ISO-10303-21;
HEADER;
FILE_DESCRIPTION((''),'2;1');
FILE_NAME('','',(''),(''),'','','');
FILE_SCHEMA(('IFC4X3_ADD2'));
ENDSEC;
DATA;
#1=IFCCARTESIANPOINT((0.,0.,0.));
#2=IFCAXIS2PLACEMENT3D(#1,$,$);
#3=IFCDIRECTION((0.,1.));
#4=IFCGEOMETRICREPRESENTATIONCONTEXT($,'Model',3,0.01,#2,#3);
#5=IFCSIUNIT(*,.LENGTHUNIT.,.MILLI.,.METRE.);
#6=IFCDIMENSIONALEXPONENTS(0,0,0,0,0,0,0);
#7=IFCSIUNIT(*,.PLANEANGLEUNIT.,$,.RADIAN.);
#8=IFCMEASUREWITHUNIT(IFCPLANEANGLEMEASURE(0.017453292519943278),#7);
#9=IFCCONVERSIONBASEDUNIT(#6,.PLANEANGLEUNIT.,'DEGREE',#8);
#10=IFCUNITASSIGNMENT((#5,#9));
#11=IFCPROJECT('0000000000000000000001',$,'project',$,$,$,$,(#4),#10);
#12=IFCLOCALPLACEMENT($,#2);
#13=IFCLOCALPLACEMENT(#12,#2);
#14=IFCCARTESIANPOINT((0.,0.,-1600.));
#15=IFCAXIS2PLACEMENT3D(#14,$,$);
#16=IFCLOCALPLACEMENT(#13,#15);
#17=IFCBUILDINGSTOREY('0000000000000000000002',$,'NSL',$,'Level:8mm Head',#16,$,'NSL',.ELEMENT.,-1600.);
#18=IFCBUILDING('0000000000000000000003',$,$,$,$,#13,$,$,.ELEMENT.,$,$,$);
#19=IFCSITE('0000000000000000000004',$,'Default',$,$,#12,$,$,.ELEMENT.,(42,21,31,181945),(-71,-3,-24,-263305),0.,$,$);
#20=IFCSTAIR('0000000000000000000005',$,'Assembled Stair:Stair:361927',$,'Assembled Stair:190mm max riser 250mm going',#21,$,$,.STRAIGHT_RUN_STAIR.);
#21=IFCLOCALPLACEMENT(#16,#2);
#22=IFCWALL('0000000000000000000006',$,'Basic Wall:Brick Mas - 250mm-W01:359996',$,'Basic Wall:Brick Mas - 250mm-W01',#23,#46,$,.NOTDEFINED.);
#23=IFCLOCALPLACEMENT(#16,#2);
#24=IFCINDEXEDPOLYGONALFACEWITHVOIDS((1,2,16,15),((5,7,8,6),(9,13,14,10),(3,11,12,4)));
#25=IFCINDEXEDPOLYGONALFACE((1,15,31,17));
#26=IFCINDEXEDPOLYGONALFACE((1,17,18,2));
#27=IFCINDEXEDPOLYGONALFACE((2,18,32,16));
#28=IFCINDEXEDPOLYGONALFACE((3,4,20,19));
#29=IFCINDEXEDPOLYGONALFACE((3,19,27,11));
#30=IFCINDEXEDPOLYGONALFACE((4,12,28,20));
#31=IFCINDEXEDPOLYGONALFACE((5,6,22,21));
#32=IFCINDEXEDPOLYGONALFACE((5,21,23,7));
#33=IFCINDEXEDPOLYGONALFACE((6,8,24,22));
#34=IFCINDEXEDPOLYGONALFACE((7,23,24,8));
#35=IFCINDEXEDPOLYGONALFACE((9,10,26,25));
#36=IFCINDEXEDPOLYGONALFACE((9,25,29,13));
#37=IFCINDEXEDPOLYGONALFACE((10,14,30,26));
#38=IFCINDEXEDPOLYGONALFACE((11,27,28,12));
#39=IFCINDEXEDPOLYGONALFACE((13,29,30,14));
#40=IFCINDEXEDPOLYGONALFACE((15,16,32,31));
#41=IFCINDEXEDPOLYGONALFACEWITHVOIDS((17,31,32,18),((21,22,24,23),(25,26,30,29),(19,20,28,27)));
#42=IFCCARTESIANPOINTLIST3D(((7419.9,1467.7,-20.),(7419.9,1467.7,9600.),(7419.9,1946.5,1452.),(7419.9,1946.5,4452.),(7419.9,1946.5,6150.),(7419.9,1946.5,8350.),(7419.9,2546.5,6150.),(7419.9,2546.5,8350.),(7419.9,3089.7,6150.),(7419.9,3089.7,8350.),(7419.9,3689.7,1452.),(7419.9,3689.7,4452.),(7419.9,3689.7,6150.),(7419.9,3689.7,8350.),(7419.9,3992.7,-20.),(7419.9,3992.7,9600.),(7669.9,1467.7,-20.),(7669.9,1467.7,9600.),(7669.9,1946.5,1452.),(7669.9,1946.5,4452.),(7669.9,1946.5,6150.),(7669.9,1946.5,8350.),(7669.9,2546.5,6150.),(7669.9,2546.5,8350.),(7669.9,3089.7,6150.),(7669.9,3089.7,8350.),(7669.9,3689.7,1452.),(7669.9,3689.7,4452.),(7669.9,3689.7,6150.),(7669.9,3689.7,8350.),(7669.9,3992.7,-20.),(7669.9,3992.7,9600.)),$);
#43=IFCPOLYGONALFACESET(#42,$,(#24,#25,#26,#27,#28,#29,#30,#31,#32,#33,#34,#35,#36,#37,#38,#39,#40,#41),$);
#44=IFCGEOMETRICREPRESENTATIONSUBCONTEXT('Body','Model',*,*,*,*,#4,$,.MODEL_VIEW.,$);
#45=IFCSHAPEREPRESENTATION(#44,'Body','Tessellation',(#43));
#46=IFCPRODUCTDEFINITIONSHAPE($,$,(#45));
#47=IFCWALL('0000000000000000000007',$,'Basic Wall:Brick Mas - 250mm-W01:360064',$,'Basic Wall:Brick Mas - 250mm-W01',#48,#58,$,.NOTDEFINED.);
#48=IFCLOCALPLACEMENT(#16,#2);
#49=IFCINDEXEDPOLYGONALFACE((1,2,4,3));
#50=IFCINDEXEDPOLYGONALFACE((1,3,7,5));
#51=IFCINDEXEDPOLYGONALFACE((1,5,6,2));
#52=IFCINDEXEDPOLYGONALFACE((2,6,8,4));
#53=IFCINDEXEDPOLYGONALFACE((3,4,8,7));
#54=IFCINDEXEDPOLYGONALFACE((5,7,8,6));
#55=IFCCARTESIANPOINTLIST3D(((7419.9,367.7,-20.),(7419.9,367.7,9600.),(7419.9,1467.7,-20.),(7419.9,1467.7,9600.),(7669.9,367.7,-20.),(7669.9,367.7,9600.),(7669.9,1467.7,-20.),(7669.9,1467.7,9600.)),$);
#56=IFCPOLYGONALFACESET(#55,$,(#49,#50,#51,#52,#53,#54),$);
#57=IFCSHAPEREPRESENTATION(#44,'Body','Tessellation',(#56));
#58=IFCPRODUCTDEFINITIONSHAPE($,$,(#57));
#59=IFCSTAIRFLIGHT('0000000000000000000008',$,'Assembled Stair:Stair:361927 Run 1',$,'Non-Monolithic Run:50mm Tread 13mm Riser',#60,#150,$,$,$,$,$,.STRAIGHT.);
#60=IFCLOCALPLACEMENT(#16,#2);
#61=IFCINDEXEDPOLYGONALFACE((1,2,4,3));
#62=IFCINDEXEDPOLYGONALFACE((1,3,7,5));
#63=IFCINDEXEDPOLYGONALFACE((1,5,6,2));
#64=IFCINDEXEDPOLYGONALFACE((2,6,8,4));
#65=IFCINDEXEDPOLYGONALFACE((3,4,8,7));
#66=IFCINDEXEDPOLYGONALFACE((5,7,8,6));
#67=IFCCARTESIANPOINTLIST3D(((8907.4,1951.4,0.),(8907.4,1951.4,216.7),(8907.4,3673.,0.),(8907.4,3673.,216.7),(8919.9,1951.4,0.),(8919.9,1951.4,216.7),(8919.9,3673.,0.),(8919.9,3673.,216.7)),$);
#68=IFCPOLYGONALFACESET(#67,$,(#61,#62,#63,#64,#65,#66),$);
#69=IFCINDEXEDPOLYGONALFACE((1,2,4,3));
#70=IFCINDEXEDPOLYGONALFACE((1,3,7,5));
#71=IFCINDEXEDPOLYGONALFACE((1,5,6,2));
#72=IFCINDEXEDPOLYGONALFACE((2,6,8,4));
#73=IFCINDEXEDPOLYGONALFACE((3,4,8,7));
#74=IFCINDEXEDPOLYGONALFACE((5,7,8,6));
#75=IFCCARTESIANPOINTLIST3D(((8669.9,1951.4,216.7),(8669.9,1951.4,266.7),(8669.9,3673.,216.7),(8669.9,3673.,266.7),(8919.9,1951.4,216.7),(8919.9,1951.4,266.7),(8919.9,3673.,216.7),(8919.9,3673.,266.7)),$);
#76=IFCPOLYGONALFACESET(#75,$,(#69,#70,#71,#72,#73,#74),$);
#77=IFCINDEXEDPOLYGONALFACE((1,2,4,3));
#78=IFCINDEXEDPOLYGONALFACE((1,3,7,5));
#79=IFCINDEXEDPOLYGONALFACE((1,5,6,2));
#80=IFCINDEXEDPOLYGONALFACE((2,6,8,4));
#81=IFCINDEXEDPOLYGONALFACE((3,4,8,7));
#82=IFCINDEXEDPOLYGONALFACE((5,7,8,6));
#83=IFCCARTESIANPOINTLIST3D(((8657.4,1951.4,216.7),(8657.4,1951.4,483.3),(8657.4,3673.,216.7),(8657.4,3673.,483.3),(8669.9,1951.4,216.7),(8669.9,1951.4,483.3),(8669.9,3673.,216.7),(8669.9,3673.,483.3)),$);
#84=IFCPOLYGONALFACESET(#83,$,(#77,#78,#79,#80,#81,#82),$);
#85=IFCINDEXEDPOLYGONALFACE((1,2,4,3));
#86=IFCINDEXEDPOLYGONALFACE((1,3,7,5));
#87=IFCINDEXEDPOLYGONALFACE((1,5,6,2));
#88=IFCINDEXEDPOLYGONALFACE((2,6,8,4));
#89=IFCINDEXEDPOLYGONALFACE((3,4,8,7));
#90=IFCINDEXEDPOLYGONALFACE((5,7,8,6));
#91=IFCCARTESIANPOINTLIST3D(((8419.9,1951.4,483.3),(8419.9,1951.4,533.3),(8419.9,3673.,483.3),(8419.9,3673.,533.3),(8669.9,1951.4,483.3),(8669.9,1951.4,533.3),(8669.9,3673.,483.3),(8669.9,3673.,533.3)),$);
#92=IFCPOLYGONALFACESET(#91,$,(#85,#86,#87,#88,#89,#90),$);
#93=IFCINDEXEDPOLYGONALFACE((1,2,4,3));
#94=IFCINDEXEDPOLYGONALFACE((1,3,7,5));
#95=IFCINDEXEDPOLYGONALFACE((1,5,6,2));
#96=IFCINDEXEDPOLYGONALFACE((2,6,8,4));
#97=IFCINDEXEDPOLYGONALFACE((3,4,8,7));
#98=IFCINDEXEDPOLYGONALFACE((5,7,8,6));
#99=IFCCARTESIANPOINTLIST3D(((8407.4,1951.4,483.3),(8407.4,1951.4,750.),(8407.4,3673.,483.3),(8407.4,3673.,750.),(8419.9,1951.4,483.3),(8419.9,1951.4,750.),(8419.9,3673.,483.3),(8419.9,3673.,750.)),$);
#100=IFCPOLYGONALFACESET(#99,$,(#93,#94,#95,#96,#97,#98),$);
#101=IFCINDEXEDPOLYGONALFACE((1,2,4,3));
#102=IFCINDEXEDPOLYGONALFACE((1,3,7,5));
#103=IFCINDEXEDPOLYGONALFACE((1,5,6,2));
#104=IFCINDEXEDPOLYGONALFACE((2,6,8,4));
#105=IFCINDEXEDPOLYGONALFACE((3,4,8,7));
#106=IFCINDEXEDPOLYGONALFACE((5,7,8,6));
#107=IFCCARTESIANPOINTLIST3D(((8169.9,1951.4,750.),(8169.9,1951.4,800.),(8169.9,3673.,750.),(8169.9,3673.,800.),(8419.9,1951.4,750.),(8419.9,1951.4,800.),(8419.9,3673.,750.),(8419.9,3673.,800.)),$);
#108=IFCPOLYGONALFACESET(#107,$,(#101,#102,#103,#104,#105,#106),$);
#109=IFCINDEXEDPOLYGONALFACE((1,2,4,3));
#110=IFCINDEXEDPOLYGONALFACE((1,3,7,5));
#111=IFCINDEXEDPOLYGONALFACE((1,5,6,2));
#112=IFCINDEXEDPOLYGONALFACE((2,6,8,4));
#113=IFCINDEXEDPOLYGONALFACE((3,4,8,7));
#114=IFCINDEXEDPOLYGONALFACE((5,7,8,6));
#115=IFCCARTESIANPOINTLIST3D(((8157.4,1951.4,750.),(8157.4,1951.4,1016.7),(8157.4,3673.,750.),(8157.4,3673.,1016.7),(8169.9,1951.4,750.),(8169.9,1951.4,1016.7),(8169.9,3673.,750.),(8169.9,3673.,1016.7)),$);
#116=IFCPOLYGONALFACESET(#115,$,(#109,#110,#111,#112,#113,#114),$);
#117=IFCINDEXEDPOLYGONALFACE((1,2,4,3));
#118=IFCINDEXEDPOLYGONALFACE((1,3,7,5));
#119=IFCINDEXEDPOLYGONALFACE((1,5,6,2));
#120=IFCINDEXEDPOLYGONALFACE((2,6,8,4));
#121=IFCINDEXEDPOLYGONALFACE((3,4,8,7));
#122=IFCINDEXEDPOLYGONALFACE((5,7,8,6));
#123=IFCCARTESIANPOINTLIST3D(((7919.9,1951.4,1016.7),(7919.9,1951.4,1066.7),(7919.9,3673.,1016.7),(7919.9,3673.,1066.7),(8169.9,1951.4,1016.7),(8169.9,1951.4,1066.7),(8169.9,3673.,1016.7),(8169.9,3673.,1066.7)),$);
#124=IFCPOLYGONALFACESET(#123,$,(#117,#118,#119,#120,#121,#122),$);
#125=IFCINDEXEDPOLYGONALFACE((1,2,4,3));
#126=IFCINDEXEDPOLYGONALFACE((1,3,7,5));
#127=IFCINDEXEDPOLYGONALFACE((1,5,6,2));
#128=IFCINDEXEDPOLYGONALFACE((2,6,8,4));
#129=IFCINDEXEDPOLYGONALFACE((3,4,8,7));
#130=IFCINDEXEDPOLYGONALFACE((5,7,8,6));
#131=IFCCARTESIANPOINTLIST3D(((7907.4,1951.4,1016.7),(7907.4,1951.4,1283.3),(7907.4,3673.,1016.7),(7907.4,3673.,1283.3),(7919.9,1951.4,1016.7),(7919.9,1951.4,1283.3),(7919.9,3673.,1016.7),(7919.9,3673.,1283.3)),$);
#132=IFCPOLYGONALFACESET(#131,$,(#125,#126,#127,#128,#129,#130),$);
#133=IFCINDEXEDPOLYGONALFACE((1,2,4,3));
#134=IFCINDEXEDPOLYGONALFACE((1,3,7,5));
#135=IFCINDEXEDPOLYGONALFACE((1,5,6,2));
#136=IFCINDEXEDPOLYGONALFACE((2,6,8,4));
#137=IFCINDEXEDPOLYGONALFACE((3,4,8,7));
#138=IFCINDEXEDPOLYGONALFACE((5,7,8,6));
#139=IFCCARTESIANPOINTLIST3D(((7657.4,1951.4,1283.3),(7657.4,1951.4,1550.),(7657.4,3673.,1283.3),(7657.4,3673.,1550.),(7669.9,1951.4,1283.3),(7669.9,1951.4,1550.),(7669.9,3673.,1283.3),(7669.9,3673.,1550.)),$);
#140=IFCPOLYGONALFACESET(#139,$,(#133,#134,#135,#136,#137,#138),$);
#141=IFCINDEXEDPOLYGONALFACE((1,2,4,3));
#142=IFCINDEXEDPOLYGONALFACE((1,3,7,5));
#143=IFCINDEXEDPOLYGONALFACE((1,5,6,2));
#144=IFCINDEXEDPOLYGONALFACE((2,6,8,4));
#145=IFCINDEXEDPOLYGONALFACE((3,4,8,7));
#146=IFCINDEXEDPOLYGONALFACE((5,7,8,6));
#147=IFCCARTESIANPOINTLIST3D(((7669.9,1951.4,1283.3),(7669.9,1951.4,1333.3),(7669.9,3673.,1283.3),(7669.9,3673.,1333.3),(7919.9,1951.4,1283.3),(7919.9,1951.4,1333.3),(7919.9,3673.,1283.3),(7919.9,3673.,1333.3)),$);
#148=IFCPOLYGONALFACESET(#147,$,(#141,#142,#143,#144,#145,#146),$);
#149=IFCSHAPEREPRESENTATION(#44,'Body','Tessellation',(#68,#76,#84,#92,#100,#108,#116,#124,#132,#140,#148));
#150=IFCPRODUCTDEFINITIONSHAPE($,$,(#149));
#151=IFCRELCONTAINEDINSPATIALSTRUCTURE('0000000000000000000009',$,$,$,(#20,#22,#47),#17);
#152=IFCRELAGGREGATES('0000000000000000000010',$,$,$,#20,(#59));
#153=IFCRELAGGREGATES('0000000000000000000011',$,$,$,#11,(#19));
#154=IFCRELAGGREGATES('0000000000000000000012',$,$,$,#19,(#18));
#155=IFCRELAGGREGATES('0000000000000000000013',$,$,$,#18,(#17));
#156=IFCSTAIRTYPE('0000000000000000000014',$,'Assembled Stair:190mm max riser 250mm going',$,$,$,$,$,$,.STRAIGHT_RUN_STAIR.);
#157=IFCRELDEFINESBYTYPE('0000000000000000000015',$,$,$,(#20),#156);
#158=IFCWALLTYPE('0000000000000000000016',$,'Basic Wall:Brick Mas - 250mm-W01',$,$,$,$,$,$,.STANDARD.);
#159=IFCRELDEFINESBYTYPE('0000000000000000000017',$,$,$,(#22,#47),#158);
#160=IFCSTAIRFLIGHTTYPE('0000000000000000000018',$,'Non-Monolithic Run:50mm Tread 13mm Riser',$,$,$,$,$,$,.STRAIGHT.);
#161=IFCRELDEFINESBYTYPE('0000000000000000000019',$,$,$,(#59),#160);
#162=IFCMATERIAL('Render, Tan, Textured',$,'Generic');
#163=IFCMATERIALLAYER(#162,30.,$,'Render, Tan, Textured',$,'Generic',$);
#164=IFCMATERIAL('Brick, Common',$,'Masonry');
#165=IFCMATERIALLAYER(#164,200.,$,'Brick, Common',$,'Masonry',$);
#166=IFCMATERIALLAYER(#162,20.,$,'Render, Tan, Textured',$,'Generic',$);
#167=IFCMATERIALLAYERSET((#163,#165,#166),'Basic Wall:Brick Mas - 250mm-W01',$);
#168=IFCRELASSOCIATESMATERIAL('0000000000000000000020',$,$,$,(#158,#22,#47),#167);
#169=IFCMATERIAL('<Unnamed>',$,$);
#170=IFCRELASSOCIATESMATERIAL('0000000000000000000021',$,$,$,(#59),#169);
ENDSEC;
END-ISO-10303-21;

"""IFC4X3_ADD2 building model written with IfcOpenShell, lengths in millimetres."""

from ifc_helpers import new_model, entity, si_unit, converted_unit, direction, frame, frame_2d, origin, origin_2d_with_axis, place, context, subcontext, project, spatial, rectangle, extrude, material, layer, layer_set, type_object, element, aggregate, save


model = new_model("IFC4X3_ADD2")

# Units and contexts
model_context = context("Model", 3, precision=0.01, world=origin(), true_north=direction((0.0, 1.0)))
body_context = subcontext(model_context, "Body", "Model", "MODEL_VIEW")
ifc_project = project(units=[si_unit("LENGTHUNIT", "METRE", prefix="MILLI"), converted_unit("PLANEANGLEUNIT", "DEGREE", entity("IfcPlaneAngleMeasure", 0.017453292519943278), si_unit("PLANEANGLEUNIT", "RADIAN"), dimensions=[0, 0, 0, 0, 0, 0, 0])], contexts=[model_context])

# Site, building, storey
site_placement = place(None, origin())
site = spatial("IfcSite", under=ifc_project, at=site_placement, Name="Default", CompositionType="ELEMENT", RefLatitude=(42, 21, 31, 181945), RefLongitude=(-71, -3, -24, -263305), RefElevation=0.0)
building_placement = place(site_placement, origin())
building = spatial("IfcBuilding", under=site, at=building_placement, CompositionType="ELEMENT")
storey_placement = place(building_placement, frame((0.0, 0.0, -1600.0)))
storey = spatial("IfcBuildingStorey", under=building, at=storey_placement, Name="NSL", ObjectType="Level:8mm Head", LongName="NSL", CompositionType="ELEMENT", Elevation=-1600.0)

# Stair
stair_type = type_object("IfcStairType", Name="Assembled Stair:190mm max riser 250mm going", PredefinedType="STRAIGHT_RUN_STAIR")
stair_placement = place(storey_placement, origin())
stair = element("IfcStair", 1, at=stair_placement, inside=storey, type_object=stair_type, Name="Assembled Stair:Stair:361927", ObjectType="Assembled Stair:190mm max riser 250mm going", PredefinedType="STRAIGHT_RUN_STAIR")
ifc_material_1 = material(Name="<Unnamed>")

# Shared definitions
ifc_material_2 = material(Name="Render, Tan, Textured", Category="Generic")
ifc_layer_1 = layer(ifc_material_2, 30.0, Name="Render, Tan, Textured", Category="Generic")
ifc_material_3 = material(Name="Brick, Common", Category="Masonry")
ifc_layer_2 = layer(ifc_material_3, 200.0, Name="Brick, Common", Category="Masonry")
ifc_layer_3 = layer(ifc_material_2, 20.0, Name="Render, Tan, Textured", Category="Generic")
ifc_layer_set_1 = layer_set([ifc_layer_1, ifc_layer_2, ifc_layer_3], Name="Basic Wall:Brick Mas - 250mm-W01")
wall_type = type_object("IfcWallType", Name="Basic Wall:Brick Mas - 250mm-W01", PredefinedType="STANDARD", material=ifc_layer_set_1)

# Wall, openings
wall_1_placement = place(storey_placement, frame((7544.9, 3992.7, -20.0), z_axis=(0.0, 0.0, 1.0), x_axis=(0.0, -1.0, 0.0)))
wall_1 = element("IfcWall", 2, at=wall_1_placement, inside=storey, type_object=wall_type, material=ifc_layer_set_1, Name="Basic Wall:Brick Mas - 250mm-W01:359996", ObjectType="Basic Wall:Brick Mas - 250mm-W01", PredefinedType="NOTDEFINED", context=body_context, shape_type="SweptSolid", body=[
    extrude(rectangle(XDim=2525.0, YDim=250.0, at=frame_2d((1262.5, 0.0), x_axis=(-1.0, 0.0))), origin(), (0.0, 0.0, 1.0), 9620.0),
])
opening_1_placement = place(wall_1_placement, origin())
element("IfcOpeningElement", 3, at=opening_1_placement, cuts=wall_1, PredefinedType="OPENING", context=body_context, shape_type="SweptSolid", body=[
    extrude(rectangle(XDim=3000.0, YDim=1743.2, at=frame_2d((0.0, 0.0), x_axis=(1.0, 0.0))), frame((1174.6, 125.0, 2972.0), z_axis=(0.0, -1.0, 0.0), x_axis=(0.0, 0.0, -1.0)), (0.0, 0.0, 1.0), 250.0),
])
opening_2_placement = place(wall_1_placement, origin())
element("IfcOpeningElement", 4, at=opening_2_placement, cuts=wall_1, PredefinedType="OPENING", context=body_context, shape_type="SweptSolid", body=[
    extrude(rectangle(XDim=2200.0, YDim=600.0, at=frame_2d((0.0, 0.0), x_axis=(1.0, 0.0))), frame((1746.2, 125.0, 7270.0), z_axis=(0.0, -1.0, 0.0), x_axis=(0.0, 0.0, -1.0)), (0.0, 0.0, 1.0), 250.0),
])
opening_3_placement = place(wall_1_placement, origin())
element("IfcOpeningElement", 5, at=opening_3_placement, cuts=wall_1, PredefinedType="OPENING", context=body_context, shape_type="SweptSolid", body=[
    extrude(rectangle(XDim=2200.0, YDim=600.0, at=origin_2d_with_axis()), frame((603.0, 125.0, 7270.0), z_axis=(0.0, -1.0, 0.0), x_axis=(0.0, 0.0, -1.0)), (0.0, 0.0, 1.0), 250.0),
])

# Wall
wall_2_placement = place(storey_placement, frame((7544.9, 1467.7, -20.0), z_axis=(0.0, 0.0, 1.0), x_axis=(0.0, -1.0, 0.0)))
element("IfcWall", 6, at=wall_2_placement, inside=storey, type_object=wall_type, material=ifc_layer_set_1, Name="Basic Wall:Brick Mas - 250mm-W01:360064", ObjectType="Basic Wall:Brick Mas - 250mm-W01", PredefinedType="NOTDEFINED", context=body_context, shape_type="SweptSolid", body=[
    extrude(rectangle(XDim=1100.0, YDim=250.0, at=frame_2d((550.0, 0.0), x_axis=(-1.0, 0.0))), origin(), (0.0, 0.0, 1.0), 9620.0),
])

# Stair flight
stair_flight_type = type_object("IfcStairFlightType", Name="Non-Monolithic Run:50mm Tread 13mm Riser", PredefinedType="STRAIGHT")
stair_flight_placement = place(stair_placement, frame((7657.4, 1951.4, 0.0)))
stair_flight = element("IfcStairFlight", 7, at=stair_flight_placement, type_object=stair_flight_type, material=ifc_material_1, Name="Assembled Stair:Stair:361927 Run 1", ObjectType="Non-Monolithic Run:50mm Tread 13mm Riser", PredefinedType="STRAIGHT", context=body_context, shape_type="SweptSolid", body=[
    extrude(rectangle(XDim=1721.7, YDim=12.5, at=origin_2d_with_axis()), frame((1256.3, 860.8, 0.0), z_axis=(0.0, 0.0, 1.0), x_axis=(0.0, -1.0, 0.0)), (0.0, 0.0, 1.0), 216.7),
    extrude(rectangle(XDim=250.0, YDim=1721.7, at=frame_2d((0.0, 0.0), x_axis=(1.0, 0.0))), frame((1137.5, 860.8, 216.7)), (0.0, 0.0, 1.0), 50.0),
    extrude(rectangle(XDim=1721.7, YDim=12.5, at=frame_2d((0.0, 0.0), x_axis=(1.0, 0.0))), frame((1006.3, 860.8, 216.7), z_axis=(0.0, 0.0, 1.0), x_axis=(0.0, -1.0, 0.0)), (0.0, 0.0, 1.0), 266.7),
    extrude(rectangle(XDim=250.0, YDim=1721.7, at=frame_2d((0.0, 0.0), x_axis=(1.0, 0.0))), frame((887.5, 860.8, 483.3)), (0.0, 0.0, 1.0), 50.0),
    extrude(rectangle(XDim=1721.7, YDim=12.5, at=frame_2d((0.0, 0.0), x_axis=(1.0, 0.0))), frame((756.3, 860.8, 483.3), z_axis=(0.0, 0.0, 1.0), x_axis=(0.0, -1.0, 0.0)), (0.0, 0.0, 1.0), 266.7),
    extrude(rectangle(XDim=250.0, YDim=1721.7, at=frame_2d((0.0, 0.0), x_axis=(1.0, 0.0))), frame((637.5, 860.8, 750.0)), (0.0, 0.0, 1.0), 50.0),
    extrude(rectangle(XDim=1721.7, YDim=12.5, at=frame_2d((0.0, 0.0), x_axis=(1.0, 0.0))), frame((506.3, 860.8, 750.0), z_axis=(0.0, 0.0, 1.0), x_axis=(0.0, -1.0, 0.0)), (0.0, 0.0, 1.0), 266.7),
    extrude(rectangle(XDim=250.0, YDim=1721.7, at=origin_2d_with_axis()), frame((387.5, 860.8, 1016.7)), (0.0, 0.0, 1.0), 50.0),
    extrude(rectangle(XDim=1721.7, YDim=12.5, at=frame_2d((0.0, 0.0), x_axis=(1.0, 0.0))), frame((256.3, 860.8, 1016.7), z_axis=(0.0, 0.0, 1.0), x_axis=(0.0, -1.0, 0.0)), (0.0, 0.0, 1.0), 266.7),
    extrude(rectangle(XDim=1721.7, YDim=12.5, at=origin_2d_with_axis()), frame((6.3, 860.8, 1283.3), z_axis=(0.0, 0.0, 1.0), x_axis=(0.0, -1.0, 0.0)), (0.0, 0.0, 1.0), 266.7),
    extrude(rectangle(XDim=250.0, YDim=1721.7, at=frame_2d((0.0, 0.0), x_axis=(1.0, 0.0))), frame((137.5, 860.8, 1283.3)), (0.0, 0.0, 1.0), 50.0),
])
aggregate(stair, [stair_flight])

save(model, "model.ifc")
